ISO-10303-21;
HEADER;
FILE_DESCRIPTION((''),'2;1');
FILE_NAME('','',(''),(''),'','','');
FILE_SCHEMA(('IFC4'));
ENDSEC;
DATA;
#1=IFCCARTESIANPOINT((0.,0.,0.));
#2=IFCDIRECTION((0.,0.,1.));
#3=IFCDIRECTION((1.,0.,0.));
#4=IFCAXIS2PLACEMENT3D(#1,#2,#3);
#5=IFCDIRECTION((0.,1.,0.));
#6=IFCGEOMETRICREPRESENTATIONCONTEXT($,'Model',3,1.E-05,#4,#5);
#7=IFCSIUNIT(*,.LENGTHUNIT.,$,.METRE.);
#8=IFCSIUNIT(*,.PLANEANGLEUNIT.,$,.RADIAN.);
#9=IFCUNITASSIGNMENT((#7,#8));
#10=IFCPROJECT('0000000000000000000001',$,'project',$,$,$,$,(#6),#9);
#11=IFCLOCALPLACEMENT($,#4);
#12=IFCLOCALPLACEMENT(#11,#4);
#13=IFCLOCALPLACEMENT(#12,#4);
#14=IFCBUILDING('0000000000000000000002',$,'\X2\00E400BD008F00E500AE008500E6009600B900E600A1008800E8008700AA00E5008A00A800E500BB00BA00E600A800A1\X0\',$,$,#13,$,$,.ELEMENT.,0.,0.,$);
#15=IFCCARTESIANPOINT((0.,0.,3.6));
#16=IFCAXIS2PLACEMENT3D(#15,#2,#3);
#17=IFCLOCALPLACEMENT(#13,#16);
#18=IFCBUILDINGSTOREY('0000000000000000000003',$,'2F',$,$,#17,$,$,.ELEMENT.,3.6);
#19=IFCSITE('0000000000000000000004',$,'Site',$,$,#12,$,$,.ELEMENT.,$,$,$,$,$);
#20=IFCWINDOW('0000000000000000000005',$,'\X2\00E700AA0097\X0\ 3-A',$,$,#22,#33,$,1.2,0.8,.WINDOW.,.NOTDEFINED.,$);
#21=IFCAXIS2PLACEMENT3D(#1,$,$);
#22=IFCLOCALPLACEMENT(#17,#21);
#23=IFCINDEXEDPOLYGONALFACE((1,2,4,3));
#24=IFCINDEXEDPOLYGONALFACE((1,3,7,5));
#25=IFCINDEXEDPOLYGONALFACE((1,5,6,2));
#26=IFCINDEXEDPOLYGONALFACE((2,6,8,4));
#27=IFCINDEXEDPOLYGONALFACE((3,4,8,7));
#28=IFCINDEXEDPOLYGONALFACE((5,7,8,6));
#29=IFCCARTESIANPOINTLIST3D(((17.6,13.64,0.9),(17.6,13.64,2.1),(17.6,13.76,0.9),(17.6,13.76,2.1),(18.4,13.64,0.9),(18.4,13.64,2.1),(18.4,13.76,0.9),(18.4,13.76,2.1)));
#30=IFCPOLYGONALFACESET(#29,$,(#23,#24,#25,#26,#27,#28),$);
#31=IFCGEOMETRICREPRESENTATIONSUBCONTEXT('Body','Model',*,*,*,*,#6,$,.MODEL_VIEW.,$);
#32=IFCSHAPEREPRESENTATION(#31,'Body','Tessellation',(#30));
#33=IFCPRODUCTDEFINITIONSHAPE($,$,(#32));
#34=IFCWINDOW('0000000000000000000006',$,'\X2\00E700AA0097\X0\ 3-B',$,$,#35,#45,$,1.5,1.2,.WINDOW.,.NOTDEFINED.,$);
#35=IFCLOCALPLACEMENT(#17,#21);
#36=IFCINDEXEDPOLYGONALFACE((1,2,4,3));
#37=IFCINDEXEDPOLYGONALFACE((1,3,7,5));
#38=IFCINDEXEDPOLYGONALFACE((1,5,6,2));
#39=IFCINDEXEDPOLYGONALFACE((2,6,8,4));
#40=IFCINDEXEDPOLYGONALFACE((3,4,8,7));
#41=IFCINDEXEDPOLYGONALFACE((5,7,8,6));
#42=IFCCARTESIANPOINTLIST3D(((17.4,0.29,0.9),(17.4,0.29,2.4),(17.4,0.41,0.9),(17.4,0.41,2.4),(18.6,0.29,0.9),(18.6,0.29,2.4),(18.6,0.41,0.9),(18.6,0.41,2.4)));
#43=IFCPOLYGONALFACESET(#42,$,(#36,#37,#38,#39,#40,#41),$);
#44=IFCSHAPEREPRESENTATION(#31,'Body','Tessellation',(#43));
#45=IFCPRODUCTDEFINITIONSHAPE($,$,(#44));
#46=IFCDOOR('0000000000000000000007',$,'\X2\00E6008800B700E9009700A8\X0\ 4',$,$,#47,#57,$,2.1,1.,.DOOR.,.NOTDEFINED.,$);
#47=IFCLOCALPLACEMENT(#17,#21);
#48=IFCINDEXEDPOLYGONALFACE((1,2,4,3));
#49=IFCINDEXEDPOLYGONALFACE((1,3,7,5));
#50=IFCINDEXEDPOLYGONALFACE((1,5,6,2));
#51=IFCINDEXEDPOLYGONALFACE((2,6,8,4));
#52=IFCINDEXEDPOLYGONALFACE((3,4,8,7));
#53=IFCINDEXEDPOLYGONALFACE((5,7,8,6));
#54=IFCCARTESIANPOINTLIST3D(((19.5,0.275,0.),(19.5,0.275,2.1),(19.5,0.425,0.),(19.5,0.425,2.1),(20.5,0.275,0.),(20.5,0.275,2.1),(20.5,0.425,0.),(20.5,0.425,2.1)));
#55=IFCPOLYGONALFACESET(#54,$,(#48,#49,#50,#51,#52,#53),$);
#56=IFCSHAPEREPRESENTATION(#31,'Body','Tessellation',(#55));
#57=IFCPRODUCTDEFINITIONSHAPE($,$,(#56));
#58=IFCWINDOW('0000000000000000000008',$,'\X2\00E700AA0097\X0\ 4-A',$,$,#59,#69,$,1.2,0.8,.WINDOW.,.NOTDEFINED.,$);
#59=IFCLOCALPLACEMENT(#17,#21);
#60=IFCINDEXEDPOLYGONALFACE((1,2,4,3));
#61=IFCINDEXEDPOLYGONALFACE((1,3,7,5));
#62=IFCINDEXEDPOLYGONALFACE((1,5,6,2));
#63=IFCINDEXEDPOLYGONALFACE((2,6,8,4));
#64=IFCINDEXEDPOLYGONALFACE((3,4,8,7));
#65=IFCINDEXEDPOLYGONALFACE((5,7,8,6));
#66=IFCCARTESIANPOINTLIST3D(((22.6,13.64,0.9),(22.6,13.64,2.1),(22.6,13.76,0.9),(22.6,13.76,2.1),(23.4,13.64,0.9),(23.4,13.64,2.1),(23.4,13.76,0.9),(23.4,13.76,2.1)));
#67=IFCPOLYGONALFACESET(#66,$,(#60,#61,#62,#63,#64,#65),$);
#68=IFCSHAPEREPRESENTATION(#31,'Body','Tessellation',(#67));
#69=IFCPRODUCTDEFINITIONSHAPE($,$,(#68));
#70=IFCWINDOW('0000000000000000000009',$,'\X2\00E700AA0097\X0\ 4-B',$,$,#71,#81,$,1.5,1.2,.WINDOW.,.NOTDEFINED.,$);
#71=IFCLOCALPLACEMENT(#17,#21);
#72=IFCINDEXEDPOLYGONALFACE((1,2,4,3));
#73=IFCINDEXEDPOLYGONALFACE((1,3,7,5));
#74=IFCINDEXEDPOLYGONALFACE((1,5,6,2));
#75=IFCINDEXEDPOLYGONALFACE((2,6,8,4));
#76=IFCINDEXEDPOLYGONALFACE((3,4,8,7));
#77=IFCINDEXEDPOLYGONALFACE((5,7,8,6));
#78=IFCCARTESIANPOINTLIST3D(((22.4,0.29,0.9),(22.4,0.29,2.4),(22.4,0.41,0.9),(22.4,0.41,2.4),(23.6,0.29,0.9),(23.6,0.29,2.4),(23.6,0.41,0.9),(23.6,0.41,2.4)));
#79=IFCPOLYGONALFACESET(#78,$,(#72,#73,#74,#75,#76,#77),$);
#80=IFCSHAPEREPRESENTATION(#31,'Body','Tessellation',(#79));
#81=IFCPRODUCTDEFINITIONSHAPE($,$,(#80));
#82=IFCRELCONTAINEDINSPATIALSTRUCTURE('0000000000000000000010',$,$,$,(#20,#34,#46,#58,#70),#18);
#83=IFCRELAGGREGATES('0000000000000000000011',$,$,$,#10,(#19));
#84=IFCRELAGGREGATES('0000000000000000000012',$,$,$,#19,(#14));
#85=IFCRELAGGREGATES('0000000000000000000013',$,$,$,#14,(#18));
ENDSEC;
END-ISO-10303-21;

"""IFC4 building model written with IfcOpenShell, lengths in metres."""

from ifc_helpers import new_model, si_unit, direction, frame, frame_2d, origin_with_axes, place, context, subcontext, project, spatial, rectangle, extrude, element, save


model = new_model("IFC4")

# Units and contexts
model_context = context("Model", 3, precision=1e-05, world=origin_with_axes(), true_north=direction((0.0, 1.0, 0.0)))
body_context = subcontext(model_context, "Body", "Model", "MODEL_VIEW")
ifc_project = project(units=[si_unit("LENGTHUNIT", "METRE"), si_unit("PLANEANGLEUNIT", "RADIAN")], contexts=[model_context])

# Site, building, storey
placement = place(None, origin_with_axes())
site_placement = place(placement, origin_with_axes())
site = spatial("IfcSite", under=ifc_project, at=site_placement, Name="Site", CompositionType="ELEMENT")
building_placement = place(site_placement, origin_with_axes())
building = spatial("IfcBuilding", under=site, at=building_placement, Name="ä½\u008få®\u0085æ\u0096¹æ¡\u0088è\u0087ªå\u008a¨å»ºæ¨¡", CompositionType="ELEMENT", ElevationOfRefHeight=0.0, ElevationOfTerrain=0.0)
storey_placement = place(building_placement, frame((0.0, 0.0, 3.6), z_axis=(0.0, 0.0, 1.0), x_axis=(1.0, 0.0, 0.0)))
storey = spatial("IfcBuildingStorey", under=building, at=storey_placement, Name="2F", CompositionType="ELEMENT", Elevation=3.6)

# Windows
window_1_placement = place(storey_placement, frame((18.0, 13.7, 0.9), z_axis=(0.0, 0.0, 1.0), x_axis=(1.0, 0.0, 0.0)))
element("IfcWindow", 1, at=window_1_placement, inside=storey, Name="çª\u0097 3-A", OverallHeight=1.2, OverallWidth=0.8, PartitioningType="NOTDEFINED", PredefinedType="WINDOW", context=body_context, shape_type="SweptSolid", body=[
    extrude(rectangle(XDim=0.8, YDim=0.12, at=frame_2d((0.0, 0.0), x_axis=(1.0, 0.0, 0.0))), frame((0.0, 0.0, 0.0), z_axis=(0.0, 0.0, 1.0)), (0.0, 0.0, 1.0), 1.2),
])
window_2_placement = place(storey_placement, frame((18.0, 0.35, 0.9), z_axis=(0.0, 0.0, 1.0), x_axis=(1.0, 0.0, 0.0)))
element("IfcWindow", 2, at=window_2_placement, inside=storey, Name="çª\u0097 3-B", OverallHeight=1.5, OverallWidth=1.2, PartitioningType="NOTDEFINED", PredefinedType="WINDOW", context=body_context, shape_type="SweptSolid", body=[
    extrude(rectangle(XDim=1.2, YDim=0.12, at=frame_2d((0.0, 0.0), x_axis=(1.0, 0.0, 0.0))), frame((0.0, 0.0, 0.0), z_axis=(0.0, 0.0, 1.0)), (0.0, 0.0, 1.0), 1.5),
])

# Door
door_1_placement = place(storey_placement, frame((20.0, 0.35, 0.0), z_axis=(0.0, 0.0, 1.0), x_axis=(1.0, 0.0, 0.0)))
element("IfcDoor", 3, at=door_1_placement, inside=storey, Name="æ\u0088·é\u0097¨ 4", OperationType="NOTDEFINED", OverallHeight=2.1, OverallWidth=1.0, PredefinedType="DOOR", context=body_context, shape_type="SweptSolid", body=[
    extrude(rectangle(XDim=1.0, YDim=0.15, at=frame_2d((0.0, 0.0), x_axis=(1.0, 0.0, 0.0))), frame((0.0, 0.0, 0.0), z_axis=(0.0, 0.0, 1.0)), (0.0, 0.0, 1.0), 2.1),
])

# Windows
window_3_placement = place(storey_placement, frame((23.0, 13.7, 0.9), z_axis=(0.0, 0.0, 1.0), x_axis=(1.0, 0.0, 0.0)))
element("IfcWindow", 4, at=window_3_placement, inside=storey, Name="çª\u0097 4-A", OverallHeight=1.2, OverallWidth=0.8, PartitioningType="NOTDEFINED", PredefinedType="WINDOW", context=body_context, shape_type="SweptSolid", body=[
    extrude(rectangle(XDim=0.8, YDim=0.12, at=frame_2d((0.0, 0.0), x_axis=(1.0, 0.0, 0.0))), frame((0.0, 0.0, 0.0), z_axis=(0.0, 0.0, 1.0)), (0.0, 0.0, 1.0), 1.2),
])
window_4_placement = place(storey_placement, frame((23.0, 0.35, 0.9), z_axis=(0.0, 0.0, 1.0), x_axis=(1.0, 0.0, 0.0)))
element("IfcWindow", 5, at=window_4_placement, inside=storey, Name="çª\u0097 4-B", OverallHeight=1.5, OverallWidth=1.2, PartitioningType="NOTDEFINED", PredefinedType="WINDOW", context=body_context, shape_type="SweptSolid", body=[
    extrude(rectangle(XDim=1.2, YDim=0.12, at=frame_2d((0.0, 0.0), x_axis=(1.0, 0.0, 0.0))), frame((0.0, 0.0, 0.0), z_axis=(0.0, 0.0, 1.0)), (0.0, 0.0, 1.0), 1.5),
])

save(model, "model.ifc")
